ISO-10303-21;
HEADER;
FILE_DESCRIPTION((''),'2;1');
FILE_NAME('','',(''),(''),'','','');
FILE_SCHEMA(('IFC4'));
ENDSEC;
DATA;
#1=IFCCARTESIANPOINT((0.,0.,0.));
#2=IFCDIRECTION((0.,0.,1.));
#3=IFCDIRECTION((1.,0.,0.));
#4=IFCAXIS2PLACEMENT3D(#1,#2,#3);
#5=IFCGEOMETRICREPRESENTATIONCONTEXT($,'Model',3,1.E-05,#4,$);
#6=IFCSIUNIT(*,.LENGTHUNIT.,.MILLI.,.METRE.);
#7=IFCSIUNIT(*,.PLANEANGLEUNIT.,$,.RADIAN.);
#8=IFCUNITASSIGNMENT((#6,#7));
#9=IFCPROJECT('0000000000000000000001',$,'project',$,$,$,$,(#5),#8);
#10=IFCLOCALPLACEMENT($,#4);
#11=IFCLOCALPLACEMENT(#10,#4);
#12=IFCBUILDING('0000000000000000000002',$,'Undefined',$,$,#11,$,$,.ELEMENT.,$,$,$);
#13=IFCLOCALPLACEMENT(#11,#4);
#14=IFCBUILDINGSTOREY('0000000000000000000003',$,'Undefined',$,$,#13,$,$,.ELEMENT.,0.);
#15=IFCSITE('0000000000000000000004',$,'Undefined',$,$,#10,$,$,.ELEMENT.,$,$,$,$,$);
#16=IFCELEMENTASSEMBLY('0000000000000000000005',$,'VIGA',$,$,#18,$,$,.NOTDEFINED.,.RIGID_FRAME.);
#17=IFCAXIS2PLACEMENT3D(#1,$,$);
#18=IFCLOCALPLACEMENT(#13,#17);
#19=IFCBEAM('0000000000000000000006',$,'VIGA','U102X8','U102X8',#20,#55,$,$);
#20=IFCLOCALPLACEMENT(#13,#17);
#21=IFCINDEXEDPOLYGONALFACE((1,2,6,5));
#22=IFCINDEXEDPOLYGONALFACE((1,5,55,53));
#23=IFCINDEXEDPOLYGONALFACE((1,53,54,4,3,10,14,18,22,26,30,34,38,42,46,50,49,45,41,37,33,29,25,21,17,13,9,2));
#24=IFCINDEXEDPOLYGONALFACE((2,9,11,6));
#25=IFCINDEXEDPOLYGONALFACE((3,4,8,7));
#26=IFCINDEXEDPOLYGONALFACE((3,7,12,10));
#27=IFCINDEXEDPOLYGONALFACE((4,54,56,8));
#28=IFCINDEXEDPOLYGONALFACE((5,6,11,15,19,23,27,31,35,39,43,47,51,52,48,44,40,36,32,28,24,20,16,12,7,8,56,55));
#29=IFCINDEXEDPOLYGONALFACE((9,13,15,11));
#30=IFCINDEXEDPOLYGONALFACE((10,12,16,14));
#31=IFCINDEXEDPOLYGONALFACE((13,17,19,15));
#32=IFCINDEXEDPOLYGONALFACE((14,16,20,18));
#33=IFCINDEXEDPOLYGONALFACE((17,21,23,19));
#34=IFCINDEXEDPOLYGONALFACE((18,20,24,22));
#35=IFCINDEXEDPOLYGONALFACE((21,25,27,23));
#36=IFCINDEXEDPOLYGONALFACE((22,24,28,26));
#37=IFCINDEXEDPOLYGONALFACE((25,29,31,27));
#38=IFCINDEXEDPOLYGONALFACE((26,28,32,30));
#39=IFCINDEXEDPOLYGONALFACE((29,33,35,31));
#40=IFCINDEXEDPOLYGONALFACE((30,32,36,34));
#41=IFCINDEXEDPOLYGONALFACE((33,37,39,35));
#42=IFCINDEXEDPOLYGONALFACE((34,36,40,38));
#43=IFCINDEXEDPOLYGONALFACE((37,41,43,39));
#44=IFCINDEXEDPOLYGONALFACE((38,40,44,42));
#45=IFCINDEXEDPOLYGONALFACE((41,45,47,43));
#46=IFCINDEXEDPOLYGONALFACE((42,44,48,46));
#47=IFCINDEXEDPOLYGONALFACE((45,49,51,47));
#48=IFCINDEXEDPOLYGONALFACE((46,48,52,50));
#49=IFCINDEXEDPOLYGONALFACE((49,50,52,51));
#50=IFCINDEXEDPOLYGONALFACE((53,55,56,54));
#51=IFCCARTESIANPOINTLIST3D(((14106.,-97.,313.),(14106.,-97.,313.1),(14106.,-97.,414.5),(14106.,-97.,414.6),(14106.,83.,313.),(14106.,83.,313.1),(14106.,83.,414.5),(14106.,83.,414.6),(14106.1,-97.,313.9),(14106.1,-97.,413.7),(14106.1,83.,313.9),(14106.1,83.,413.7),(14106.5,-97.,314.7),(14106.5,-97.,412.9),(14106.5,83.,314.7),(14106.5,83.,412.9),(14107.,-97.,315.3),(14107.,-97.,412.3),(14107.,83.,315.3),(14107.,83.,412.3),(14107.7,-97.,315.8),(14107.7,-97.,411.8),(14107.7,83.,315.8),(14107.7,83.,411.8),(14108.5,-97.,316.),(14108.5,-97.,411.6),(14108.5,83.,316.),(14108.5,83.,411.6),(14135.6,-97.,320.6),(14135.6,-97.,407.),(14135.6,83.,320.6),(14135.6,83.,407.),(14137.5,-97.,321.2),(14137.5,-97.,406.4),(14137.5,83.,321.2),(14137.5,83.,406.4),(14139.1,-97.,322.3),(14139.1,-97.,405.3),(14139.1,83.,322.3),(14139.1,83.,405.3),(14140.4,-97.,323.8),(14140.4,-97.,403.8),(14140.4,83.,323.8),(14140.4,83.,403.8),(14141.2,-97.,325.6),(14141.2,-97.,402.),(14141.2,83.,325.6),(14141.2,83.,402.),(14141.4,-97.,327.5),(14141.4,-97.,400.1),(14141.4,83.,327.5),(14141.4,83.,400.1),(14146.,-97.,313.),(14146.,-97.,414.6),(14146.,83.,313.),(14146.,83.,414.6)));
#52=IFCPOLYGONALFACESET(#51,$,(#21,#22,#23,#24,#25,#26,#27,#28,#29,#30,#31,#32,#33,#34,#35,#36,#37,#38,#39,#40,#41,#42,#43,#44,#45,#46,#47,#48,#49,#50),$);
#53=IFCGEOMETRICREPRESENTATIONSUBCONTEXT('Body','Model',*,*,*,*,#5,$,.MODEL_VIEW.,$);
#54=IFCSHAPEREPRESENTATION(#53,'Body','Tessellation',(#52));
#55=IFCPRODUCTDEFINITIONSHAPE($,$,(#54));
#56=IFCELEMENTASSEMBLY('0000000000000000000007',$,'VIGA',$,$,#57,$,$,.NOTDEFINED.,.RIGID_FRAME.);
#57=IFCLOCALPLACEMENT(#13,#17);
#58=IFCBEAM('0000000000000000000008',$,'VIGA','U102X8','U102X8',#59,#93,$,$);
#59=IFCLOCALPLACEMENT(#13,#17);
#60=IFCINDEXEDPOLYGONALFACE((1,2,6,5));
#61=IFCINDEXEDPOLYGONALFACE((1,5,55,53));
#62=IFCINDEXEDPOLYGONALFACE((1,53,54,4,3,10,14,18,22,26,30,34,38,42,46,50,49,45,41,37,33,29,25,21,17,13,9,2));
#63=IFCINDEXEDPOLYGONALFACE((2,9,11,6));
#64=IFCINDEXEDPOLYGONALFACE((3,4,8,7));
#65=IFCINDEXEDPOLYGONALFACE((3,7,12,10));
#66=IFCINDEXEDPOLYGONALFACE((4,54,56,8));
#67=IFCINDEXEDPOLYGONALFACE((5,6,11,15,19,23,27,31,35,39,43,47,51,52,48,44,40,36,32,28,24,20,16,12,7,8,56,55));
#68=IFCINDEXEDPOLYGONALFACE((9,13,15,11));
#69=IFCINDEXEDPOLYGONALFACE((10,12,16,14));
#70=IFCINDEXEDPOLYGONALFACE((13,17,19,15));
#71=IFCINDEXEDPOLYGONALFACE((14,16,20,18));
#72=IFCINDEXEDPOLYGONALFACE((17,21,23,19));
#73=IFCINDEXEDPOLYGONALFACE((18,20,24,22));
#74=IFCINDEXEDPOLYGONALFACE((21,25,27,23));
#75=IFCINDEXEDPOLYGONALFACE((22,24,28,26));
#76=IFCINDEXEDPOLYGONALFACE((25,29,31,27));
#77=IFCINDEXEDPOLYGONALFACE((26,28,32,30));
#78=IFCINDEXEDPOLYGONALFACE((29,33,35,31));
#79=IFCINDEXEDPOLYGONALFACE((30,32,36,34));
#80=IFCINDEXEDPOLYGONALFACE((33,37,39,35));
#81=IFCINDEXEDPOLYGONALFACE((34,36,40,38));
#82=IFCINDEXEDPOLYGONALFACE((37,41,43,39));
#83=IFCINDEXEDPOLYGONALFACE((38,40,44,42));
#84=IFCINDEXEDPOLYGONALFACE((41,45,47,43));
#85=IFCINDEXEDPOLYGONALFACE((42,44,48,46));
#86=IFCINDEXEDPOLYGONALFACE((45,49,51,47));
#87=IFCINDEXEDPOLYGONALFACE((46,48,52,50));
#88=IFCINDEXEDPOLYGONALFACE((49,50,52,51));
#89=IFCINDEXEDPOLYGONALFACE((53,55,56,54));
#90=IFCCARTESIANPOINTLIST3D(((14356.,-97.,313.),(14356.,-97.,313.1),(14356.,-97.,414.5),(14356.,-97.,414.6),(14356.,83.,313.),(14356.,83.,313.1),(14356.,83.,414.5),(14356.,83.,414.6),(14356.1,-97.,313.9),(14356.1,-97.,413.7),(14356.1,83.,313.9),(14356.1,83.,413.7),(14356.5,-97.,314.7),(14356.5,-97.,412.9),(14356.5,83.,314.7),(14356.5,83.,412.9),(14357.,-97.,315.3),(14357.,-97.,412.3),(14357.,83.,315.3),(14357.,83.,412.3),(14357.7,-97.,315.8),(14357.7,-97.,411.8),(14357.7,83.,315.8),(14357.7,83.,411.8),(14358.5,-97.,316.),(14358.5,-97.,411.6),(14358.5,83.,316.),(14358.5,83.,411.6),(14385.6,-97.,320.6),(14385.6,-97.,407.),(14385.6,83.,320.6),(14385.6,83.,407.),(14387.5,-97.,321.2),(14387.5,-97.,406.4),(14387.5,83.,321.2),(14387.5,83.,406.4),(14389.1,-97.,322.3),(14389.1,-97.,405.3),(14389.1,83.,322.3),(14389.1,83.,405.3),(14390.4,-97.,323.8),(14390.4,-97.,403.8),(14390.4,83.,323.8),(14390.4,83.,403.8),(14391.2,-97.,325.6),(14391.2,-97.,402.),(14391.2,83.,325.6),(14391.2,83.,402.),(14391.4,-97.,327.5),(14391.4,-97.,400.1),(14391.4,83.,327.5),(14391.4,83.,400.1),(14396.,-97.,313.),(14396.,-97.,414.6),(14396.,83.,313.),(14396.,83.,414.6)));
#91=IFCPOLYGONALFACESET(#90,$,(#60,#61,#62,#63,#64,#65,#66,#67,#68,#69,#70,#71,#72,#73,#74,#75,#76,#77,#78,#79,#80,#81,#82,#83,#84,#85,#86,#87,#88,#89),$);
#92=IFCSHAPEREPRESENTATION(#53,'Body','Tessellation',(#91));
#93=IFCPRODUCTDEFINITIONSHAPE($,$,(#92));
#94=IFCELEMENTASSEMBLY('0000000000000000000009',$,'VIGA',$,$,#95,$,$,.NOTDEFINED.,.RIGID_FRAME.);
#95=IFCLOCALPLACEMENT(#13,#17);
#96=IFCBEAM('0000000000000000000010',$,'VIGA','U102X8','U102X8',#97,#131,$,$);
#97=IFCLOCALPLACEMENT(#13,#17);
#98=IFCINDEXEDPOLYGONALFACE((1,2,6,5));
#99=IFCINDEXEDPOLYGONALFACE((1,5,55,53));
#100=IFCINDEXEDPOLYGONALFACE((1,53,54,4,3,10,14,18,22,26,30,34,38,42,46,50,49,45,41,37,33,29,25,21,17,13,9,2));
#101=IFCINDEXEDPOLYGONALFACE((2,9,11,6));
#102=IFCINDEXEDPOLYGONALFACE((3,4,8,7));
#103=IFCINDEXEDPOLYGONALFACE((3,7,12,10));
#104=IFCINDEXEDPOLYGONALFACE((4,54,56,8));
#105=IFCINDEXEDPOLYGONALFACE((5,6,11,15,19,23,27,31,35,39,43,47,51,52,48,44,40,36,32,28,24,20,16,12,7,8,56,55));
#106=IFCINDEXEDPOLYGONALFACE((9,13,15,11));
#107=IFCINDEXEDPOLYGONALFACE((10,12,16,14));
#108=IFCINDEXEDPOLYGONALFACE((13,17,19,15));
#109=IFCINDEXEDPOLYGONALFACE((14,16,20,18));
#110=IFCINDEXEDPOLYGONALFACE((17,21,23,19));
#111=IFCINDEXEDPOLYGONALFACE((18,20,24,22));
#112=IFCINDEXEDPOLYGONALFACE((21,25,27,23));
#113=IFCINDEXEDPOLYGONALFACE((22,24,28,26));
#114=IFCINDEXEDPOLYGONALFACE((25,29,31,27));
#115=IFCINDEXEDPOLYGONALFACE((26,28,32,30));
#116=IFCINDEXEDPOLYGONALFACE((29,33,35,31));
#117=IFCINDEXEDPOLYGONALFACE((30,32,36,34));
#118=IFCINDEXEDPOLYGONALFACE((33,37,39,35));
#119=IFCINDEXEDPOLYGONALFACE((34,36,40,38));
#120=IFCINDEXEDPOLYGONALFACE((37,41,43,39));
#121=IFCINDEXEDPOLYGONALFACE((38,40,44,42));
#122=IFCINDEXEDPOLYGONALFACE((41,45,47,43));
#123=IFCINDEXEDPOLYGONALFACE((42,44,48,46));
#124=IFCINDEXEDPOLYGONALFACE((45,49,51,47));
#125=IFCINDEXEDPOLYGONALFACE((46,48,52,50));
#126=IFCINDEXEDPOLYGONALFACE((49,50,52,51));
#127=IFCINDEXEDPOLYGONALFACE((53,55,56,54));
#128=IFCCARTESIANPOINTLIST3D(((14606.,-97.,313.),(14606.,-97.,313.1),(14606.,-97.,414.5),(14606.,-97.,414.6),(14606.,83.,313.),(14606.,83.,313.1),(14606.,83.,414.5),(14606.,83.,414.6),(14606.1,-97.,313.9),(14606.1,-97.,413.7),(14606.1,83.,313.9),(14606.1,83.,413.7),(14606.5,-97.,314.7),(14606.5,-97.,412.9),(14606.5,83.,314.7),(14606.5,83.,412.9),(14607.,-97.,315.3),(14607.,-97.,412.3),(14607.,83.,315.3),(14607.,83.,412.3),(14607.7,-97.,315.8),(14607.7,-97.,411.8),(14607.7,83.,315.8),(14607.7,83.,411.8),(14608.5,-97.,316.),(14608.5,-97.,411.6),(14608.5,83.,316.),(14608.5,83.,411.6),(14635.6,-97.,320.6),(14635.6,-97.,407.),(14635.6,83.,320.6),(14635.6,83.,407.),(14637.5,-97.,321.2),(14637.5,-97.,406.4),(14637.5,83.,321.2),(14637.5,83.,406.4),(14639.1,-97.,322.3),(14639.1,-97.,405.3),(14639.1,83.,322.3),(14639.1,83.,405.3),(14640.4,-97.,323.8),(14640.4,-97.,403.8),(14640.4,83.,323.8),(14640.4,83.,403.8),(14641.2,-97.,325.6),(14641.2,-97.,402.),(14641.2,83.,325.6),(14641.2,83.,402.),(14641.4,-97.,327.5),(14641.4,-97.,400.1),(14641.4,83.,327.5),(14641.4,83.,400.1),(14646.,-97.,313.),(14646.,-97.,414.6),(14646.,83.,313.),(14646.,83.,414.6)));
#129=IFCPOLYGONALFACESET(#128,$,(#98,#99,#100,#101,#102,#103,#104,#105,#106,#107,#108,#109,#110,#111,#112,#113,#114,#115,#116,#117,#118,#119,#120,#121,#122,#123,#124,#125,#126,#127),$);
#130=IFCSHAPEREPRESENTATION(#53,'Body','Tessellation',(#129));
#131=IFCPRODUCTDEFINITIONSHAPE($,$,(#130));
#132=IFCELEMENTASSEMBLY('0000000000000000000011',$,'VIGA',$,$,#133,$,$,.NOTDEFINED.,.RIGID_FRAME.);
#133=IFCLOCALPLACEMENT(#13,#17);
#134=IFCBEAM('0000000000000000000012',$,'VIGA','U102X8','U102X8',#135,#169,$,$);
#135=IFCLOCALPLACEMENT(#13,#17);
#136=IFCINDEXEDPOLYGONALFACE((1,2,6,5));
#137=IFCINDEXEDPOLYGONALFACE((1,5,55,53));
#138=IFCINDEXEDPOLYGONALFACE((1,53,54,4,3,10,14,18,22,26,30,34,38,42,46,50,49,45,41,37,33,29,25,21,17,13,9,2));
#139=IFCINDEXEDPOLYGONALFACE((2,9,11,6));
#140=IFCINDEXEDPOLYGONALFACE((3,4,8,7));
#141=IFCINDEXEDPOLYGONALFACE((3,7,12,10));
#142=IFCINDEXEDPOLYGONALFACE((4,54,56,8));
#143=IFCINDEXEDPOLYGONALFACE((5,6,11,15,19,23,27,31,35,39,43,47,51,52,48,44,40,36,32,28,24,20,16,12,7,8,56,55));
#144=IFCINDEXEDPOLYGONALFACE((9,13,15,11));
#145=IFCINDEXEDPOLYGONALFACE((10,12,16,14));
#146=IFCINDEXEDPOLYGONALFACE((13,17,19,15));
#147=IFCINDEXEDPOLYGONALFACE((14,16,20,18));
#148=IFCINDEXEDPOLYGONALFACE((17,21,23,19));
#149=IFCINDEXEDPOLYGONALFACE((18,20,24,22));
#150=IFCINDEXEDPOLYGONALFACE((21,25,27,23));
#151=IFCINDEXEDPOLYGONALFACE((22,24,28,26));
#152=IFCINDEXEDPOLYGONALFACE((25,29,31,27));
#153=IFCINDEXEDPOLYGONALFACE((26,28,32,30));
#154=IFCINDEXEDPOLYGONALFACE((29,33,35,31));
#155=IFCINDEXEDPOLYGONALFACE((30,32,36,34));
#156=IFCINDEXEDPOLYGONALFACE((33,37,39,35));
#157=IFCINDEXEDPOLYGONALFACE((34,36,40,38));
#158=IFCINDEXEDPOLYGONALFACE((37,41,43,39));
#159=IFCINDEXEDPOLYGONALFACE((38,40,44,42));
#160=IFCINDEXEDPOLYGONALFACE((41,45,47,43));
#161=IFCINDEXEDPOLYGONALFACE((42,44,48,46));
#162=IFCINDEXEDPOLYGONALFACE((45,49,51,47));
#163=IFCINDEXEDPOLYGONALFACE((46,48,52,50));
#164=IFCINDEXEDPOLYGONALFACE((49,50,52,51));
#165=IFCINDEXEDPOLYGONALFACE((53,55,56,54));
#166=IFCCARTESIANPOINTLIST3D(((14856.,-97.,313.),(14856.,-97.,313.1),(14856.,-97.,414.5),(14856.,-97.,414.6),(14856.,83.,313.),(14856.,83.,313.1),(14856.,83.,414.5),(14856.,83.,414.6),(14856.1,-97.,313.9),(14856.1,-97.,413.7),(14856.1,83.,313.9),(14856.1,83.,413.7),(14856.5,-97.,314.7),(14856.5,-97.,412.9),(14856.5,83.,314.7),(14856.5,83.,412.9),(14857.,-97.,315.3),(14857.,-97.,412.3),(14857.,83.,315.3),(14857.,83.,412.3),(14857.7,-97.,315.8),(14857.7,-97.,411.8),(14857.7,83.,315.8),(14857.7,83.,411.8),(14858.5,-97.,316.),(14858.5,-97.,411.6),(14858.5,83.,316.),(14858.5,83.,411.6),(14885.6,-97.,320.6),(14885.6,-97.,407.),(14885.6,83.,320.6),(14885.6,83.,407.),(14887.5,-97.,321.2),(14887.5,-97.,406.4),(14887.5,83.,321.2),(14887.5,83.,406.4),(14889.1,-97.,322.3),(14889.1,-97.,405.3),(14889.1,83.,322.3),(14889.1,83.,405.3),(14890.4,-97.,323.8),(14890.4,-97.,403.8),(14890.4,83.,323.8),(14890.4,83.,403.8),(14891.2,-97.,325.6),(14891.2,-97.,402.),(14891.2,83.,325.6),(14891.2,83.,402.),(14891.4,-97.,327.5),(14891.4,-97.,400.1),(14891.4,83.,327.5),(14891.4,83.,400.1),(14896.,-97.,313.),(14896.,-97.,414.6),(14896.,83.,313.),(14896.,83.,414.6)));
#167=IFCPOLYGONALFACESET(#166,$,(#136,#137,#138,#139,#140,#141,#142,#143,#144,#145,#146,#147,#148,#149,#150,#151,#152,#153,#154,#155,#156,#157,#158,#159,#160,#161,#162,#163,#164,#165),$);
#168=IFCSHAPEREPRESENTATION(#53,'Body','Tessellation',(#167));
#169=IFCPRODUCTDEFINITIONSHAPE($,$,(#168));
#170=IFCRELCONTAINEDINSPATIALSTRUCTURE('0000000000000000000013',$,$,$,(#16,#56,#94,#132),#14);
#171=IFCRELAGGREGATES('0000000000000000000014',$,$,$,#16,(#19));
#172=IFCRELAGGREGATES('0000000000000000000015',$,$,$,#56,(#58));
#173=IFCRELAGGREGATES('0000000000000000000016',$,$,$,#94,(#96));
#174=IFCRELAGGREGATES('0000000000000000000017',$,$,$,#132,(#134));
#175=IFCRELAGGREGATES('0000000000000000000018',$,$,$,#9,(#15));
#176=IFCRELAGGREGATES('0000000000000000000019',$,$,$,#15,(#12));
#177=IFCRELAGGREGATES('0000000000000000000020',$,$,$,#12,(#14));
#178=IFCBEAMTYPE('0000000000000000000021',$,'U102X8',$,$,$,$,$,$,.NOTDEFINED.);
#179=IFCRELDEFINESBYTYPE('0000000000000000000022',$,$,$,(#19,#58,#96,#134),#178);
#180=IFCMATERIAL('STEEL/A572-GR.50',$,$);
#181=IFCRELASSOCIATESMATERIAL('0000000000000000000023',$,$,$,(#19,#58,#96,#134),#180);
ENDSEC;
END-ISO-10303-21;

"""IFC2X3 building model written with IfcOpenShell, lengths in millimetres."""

from ifc_helpers import new_model, si_unit, frame, origin_with_axes, origin_2d_with_axis, place, context, subcontext, project, spatial, u_section, extrude, material, type_object, element, aggregate, save


model = new_model("IFC2X3")

# Units and contexts
model_context = context("Model", 3, precision=1e-05, world=origin_with_axes())
body_context = subcontext(model_context, "Body", "Model", "MODEL_VIEW")
ifc_project = project(units=[si_unit("LENGTHUNIT", "METRE", prefix="MILLI"), si_unit("PLANEANGLEUNIT", "RADIAN")], contexts=[model_context])

# Site, building, storey
site_placement = place(None, origin_with_axes())
site = spatial("IfcSite", under=ifc_project, at=site_placement, Name="Undefined", CompositionType="ELEMENT")
building_placement = place(site_placement, origin_with_axes())
building = spatial("IfcBuilding", under=site, at=building_placement, Name="Undefined", CompositionType="ELEMENT")
storey_placement = place(building_placement, origin_with_axes())
storey = spatial("IfcBuildingStorey", under=building, at=storey_placement, Name="Undefined", CompositionType="ELEMENT", Elevation=0.0)

# Element assemblies, beams
ifc_material_1 = material(Name="STEEL/A572-GR.50")
beam_type_1 = type_object("IfcBeamType", Name="U102X8", PredefinedType="NOTDEFINED")
assembly_1_placement = place(storey_placement, origin_with_axes())
assembly_1 = element("IfcElementAssembly", 1, at=assembly_1_placement, inside=storey, Name="VIGA", AssemblyPlace="NOTDEFINED", PredefinedType="RIGID_FRAME")
beam_1_placement = place(assembly_1_placement, frame((14126.0, 83.0, 363.8), z_axis=(0.0, 0.0, 1.0), x_axis=(0.0, -1.0, 0.0)))
beam_1 = element("IfcBeam", 2, at=beam_1_placement, type_object=beam_type_1, material=ifc_material_1, Name="VIGA", Description="U102X8", ObjectType="U102X8", context=body_context, shape_type="SweptSolid", body=[
    extrude(u_section(Depth=101.6, FlangeWidth=40.0, WebThickness=4.6, FlangeThickness=6.0, FilletRadius=7.0, EdgeRadius=3.0, FlangeSlope=0.16839, at=origin_2d_with_axis()), frame((180.0, 0.0, 0.0), z_axis=(-1.0, 0.0, 0.0), x_axis=(0.0, -1.0, 0.0)), (0.0, 0.0, 1.0), 180.0),
])
aggregate(assembly_1, [beam_1])
assembly_2_placement = place(storey_placement, origin_with_axes())
assembly_2 = element("IfcElementAssembly", 3, at=assembly_2_placement, inside=storey, Name="VIGA", AssemblyPlace="NOTDEFINED", PredefinedType="RIGID_FRAME")
beam_2_placement = place(assembly_2_placement, frame((14376.0, 83.0, 363.8), z_axis=(0.0, 0.0, 1.0), x_axis=(0.0, -1.0, 0.0)))
beam_2 = element("IfcBeam", 4, at=beam_2_placement, type_object=beam_type_1, material=ifc_material_1, Name="VIGA", Description="U102X8", ObjectType="U102X8", context=body_context, shape_type="SweptSolid", body=[
    extrude(u_section(Depth=101.6, FlangeWidth=40.0, WebThickness=4.6, FlangeThickness=6.0, FilletRadius=7.0, EdgeRadius=3.0, FlangeSlope=0.16839, at=origin_2d_with_axis()), frame((180.0, 0.0, 0.0), z_axis=(-1.0, 0.0, 0.0), x_axis=(0.0, -1.0, 0.0)), (0.0, 0.0, 1.0), 180.0),
])
aggregate(assembly_2, [beam_2])
assembly_3_placement = place(storey_placement, origin_with_axes())
assembly_3 = element("IfcElementAssembly", 5, at=assembly_3_placement, inside=storey, Name="VIGA", AssemblyPlace="NOTDEFINED", PredefinedType="RIGID_FRAME")
beam_3_placement = place(assembly_3_placement, frame((14626.0, 83.0, 363.8), z_axis=(0.0, 0.0, 1.0), x_axis=(0.0, -1.0, 0.0)))
beam_3 = element("IfcBeam", 6, at=beam_3_placement, type_object=beam_type_1, material=ifc_material_1, Name="VIGA", Description="U102X8", ObjectType="U102X8", context=body_context, shape_type="SweptSolid", body=[
    extrude(u_section(Depth=101.6, FlangeWidth=40.0, WebThickness=4.6, FlangeThickness=6.0, FilletRadius=7.0, EdgeRadius=3.0, FlangeSlope=0.16839, at=origin_2d_with_axis()), frame((180.0, 0.0, 0.0), z_axis=(-1.0, 0.0, 0.0), x_axis=(0.0, -1.0, 0.0)), (0.0, 0.0, 1.0), 180.0),
])
aggregate(assembly_3, [beam_3])
assembly_4_placement = place(storey_placement, origin_with_axes())
assembly_4 = element("IfcElementAssembly", 7, at=assembly_4_placement, inside=storey, Name="VIGA", AssemblyPlace="NOTDEFINED", PredefinedType="RIGID_FRAME")
beam_4_placement = place(assembly_4_placement, frame((14876.0, 83.0, 363.8), z_axis=(0.0, 0.0, 1.0), x_axis=(0.0, -1.0, 0.0)))
beam_4 = element("IfcBeam", 8, at=beam_4_placement, type_object=beam_type_1, material=ifc_material_1, Name="VIGA", Description="U102X8", ObjectType="U102X8", context=body_context, shape_type="SweptSolid", body=[
    extrude(u_section(Depth=101.6, FlangeWidth=40.0, WebThickness=4.6, FlangeThickness=6.0, FilletRadius=7.0, EdgeRadius=3.0, FlangeSlope=0.16839, at=origin_2d_with_axis()), frame((180.0, 0.0, 0.0), z_axis=(-1.0, 0.0, 0.0), x_axis=(0.0, -1.0, 0.0)), (0.0, 0.0, 1.0), 180.0),
])
aggregate(assembly_4, [beam_4])

save(model, "model.ifc")
